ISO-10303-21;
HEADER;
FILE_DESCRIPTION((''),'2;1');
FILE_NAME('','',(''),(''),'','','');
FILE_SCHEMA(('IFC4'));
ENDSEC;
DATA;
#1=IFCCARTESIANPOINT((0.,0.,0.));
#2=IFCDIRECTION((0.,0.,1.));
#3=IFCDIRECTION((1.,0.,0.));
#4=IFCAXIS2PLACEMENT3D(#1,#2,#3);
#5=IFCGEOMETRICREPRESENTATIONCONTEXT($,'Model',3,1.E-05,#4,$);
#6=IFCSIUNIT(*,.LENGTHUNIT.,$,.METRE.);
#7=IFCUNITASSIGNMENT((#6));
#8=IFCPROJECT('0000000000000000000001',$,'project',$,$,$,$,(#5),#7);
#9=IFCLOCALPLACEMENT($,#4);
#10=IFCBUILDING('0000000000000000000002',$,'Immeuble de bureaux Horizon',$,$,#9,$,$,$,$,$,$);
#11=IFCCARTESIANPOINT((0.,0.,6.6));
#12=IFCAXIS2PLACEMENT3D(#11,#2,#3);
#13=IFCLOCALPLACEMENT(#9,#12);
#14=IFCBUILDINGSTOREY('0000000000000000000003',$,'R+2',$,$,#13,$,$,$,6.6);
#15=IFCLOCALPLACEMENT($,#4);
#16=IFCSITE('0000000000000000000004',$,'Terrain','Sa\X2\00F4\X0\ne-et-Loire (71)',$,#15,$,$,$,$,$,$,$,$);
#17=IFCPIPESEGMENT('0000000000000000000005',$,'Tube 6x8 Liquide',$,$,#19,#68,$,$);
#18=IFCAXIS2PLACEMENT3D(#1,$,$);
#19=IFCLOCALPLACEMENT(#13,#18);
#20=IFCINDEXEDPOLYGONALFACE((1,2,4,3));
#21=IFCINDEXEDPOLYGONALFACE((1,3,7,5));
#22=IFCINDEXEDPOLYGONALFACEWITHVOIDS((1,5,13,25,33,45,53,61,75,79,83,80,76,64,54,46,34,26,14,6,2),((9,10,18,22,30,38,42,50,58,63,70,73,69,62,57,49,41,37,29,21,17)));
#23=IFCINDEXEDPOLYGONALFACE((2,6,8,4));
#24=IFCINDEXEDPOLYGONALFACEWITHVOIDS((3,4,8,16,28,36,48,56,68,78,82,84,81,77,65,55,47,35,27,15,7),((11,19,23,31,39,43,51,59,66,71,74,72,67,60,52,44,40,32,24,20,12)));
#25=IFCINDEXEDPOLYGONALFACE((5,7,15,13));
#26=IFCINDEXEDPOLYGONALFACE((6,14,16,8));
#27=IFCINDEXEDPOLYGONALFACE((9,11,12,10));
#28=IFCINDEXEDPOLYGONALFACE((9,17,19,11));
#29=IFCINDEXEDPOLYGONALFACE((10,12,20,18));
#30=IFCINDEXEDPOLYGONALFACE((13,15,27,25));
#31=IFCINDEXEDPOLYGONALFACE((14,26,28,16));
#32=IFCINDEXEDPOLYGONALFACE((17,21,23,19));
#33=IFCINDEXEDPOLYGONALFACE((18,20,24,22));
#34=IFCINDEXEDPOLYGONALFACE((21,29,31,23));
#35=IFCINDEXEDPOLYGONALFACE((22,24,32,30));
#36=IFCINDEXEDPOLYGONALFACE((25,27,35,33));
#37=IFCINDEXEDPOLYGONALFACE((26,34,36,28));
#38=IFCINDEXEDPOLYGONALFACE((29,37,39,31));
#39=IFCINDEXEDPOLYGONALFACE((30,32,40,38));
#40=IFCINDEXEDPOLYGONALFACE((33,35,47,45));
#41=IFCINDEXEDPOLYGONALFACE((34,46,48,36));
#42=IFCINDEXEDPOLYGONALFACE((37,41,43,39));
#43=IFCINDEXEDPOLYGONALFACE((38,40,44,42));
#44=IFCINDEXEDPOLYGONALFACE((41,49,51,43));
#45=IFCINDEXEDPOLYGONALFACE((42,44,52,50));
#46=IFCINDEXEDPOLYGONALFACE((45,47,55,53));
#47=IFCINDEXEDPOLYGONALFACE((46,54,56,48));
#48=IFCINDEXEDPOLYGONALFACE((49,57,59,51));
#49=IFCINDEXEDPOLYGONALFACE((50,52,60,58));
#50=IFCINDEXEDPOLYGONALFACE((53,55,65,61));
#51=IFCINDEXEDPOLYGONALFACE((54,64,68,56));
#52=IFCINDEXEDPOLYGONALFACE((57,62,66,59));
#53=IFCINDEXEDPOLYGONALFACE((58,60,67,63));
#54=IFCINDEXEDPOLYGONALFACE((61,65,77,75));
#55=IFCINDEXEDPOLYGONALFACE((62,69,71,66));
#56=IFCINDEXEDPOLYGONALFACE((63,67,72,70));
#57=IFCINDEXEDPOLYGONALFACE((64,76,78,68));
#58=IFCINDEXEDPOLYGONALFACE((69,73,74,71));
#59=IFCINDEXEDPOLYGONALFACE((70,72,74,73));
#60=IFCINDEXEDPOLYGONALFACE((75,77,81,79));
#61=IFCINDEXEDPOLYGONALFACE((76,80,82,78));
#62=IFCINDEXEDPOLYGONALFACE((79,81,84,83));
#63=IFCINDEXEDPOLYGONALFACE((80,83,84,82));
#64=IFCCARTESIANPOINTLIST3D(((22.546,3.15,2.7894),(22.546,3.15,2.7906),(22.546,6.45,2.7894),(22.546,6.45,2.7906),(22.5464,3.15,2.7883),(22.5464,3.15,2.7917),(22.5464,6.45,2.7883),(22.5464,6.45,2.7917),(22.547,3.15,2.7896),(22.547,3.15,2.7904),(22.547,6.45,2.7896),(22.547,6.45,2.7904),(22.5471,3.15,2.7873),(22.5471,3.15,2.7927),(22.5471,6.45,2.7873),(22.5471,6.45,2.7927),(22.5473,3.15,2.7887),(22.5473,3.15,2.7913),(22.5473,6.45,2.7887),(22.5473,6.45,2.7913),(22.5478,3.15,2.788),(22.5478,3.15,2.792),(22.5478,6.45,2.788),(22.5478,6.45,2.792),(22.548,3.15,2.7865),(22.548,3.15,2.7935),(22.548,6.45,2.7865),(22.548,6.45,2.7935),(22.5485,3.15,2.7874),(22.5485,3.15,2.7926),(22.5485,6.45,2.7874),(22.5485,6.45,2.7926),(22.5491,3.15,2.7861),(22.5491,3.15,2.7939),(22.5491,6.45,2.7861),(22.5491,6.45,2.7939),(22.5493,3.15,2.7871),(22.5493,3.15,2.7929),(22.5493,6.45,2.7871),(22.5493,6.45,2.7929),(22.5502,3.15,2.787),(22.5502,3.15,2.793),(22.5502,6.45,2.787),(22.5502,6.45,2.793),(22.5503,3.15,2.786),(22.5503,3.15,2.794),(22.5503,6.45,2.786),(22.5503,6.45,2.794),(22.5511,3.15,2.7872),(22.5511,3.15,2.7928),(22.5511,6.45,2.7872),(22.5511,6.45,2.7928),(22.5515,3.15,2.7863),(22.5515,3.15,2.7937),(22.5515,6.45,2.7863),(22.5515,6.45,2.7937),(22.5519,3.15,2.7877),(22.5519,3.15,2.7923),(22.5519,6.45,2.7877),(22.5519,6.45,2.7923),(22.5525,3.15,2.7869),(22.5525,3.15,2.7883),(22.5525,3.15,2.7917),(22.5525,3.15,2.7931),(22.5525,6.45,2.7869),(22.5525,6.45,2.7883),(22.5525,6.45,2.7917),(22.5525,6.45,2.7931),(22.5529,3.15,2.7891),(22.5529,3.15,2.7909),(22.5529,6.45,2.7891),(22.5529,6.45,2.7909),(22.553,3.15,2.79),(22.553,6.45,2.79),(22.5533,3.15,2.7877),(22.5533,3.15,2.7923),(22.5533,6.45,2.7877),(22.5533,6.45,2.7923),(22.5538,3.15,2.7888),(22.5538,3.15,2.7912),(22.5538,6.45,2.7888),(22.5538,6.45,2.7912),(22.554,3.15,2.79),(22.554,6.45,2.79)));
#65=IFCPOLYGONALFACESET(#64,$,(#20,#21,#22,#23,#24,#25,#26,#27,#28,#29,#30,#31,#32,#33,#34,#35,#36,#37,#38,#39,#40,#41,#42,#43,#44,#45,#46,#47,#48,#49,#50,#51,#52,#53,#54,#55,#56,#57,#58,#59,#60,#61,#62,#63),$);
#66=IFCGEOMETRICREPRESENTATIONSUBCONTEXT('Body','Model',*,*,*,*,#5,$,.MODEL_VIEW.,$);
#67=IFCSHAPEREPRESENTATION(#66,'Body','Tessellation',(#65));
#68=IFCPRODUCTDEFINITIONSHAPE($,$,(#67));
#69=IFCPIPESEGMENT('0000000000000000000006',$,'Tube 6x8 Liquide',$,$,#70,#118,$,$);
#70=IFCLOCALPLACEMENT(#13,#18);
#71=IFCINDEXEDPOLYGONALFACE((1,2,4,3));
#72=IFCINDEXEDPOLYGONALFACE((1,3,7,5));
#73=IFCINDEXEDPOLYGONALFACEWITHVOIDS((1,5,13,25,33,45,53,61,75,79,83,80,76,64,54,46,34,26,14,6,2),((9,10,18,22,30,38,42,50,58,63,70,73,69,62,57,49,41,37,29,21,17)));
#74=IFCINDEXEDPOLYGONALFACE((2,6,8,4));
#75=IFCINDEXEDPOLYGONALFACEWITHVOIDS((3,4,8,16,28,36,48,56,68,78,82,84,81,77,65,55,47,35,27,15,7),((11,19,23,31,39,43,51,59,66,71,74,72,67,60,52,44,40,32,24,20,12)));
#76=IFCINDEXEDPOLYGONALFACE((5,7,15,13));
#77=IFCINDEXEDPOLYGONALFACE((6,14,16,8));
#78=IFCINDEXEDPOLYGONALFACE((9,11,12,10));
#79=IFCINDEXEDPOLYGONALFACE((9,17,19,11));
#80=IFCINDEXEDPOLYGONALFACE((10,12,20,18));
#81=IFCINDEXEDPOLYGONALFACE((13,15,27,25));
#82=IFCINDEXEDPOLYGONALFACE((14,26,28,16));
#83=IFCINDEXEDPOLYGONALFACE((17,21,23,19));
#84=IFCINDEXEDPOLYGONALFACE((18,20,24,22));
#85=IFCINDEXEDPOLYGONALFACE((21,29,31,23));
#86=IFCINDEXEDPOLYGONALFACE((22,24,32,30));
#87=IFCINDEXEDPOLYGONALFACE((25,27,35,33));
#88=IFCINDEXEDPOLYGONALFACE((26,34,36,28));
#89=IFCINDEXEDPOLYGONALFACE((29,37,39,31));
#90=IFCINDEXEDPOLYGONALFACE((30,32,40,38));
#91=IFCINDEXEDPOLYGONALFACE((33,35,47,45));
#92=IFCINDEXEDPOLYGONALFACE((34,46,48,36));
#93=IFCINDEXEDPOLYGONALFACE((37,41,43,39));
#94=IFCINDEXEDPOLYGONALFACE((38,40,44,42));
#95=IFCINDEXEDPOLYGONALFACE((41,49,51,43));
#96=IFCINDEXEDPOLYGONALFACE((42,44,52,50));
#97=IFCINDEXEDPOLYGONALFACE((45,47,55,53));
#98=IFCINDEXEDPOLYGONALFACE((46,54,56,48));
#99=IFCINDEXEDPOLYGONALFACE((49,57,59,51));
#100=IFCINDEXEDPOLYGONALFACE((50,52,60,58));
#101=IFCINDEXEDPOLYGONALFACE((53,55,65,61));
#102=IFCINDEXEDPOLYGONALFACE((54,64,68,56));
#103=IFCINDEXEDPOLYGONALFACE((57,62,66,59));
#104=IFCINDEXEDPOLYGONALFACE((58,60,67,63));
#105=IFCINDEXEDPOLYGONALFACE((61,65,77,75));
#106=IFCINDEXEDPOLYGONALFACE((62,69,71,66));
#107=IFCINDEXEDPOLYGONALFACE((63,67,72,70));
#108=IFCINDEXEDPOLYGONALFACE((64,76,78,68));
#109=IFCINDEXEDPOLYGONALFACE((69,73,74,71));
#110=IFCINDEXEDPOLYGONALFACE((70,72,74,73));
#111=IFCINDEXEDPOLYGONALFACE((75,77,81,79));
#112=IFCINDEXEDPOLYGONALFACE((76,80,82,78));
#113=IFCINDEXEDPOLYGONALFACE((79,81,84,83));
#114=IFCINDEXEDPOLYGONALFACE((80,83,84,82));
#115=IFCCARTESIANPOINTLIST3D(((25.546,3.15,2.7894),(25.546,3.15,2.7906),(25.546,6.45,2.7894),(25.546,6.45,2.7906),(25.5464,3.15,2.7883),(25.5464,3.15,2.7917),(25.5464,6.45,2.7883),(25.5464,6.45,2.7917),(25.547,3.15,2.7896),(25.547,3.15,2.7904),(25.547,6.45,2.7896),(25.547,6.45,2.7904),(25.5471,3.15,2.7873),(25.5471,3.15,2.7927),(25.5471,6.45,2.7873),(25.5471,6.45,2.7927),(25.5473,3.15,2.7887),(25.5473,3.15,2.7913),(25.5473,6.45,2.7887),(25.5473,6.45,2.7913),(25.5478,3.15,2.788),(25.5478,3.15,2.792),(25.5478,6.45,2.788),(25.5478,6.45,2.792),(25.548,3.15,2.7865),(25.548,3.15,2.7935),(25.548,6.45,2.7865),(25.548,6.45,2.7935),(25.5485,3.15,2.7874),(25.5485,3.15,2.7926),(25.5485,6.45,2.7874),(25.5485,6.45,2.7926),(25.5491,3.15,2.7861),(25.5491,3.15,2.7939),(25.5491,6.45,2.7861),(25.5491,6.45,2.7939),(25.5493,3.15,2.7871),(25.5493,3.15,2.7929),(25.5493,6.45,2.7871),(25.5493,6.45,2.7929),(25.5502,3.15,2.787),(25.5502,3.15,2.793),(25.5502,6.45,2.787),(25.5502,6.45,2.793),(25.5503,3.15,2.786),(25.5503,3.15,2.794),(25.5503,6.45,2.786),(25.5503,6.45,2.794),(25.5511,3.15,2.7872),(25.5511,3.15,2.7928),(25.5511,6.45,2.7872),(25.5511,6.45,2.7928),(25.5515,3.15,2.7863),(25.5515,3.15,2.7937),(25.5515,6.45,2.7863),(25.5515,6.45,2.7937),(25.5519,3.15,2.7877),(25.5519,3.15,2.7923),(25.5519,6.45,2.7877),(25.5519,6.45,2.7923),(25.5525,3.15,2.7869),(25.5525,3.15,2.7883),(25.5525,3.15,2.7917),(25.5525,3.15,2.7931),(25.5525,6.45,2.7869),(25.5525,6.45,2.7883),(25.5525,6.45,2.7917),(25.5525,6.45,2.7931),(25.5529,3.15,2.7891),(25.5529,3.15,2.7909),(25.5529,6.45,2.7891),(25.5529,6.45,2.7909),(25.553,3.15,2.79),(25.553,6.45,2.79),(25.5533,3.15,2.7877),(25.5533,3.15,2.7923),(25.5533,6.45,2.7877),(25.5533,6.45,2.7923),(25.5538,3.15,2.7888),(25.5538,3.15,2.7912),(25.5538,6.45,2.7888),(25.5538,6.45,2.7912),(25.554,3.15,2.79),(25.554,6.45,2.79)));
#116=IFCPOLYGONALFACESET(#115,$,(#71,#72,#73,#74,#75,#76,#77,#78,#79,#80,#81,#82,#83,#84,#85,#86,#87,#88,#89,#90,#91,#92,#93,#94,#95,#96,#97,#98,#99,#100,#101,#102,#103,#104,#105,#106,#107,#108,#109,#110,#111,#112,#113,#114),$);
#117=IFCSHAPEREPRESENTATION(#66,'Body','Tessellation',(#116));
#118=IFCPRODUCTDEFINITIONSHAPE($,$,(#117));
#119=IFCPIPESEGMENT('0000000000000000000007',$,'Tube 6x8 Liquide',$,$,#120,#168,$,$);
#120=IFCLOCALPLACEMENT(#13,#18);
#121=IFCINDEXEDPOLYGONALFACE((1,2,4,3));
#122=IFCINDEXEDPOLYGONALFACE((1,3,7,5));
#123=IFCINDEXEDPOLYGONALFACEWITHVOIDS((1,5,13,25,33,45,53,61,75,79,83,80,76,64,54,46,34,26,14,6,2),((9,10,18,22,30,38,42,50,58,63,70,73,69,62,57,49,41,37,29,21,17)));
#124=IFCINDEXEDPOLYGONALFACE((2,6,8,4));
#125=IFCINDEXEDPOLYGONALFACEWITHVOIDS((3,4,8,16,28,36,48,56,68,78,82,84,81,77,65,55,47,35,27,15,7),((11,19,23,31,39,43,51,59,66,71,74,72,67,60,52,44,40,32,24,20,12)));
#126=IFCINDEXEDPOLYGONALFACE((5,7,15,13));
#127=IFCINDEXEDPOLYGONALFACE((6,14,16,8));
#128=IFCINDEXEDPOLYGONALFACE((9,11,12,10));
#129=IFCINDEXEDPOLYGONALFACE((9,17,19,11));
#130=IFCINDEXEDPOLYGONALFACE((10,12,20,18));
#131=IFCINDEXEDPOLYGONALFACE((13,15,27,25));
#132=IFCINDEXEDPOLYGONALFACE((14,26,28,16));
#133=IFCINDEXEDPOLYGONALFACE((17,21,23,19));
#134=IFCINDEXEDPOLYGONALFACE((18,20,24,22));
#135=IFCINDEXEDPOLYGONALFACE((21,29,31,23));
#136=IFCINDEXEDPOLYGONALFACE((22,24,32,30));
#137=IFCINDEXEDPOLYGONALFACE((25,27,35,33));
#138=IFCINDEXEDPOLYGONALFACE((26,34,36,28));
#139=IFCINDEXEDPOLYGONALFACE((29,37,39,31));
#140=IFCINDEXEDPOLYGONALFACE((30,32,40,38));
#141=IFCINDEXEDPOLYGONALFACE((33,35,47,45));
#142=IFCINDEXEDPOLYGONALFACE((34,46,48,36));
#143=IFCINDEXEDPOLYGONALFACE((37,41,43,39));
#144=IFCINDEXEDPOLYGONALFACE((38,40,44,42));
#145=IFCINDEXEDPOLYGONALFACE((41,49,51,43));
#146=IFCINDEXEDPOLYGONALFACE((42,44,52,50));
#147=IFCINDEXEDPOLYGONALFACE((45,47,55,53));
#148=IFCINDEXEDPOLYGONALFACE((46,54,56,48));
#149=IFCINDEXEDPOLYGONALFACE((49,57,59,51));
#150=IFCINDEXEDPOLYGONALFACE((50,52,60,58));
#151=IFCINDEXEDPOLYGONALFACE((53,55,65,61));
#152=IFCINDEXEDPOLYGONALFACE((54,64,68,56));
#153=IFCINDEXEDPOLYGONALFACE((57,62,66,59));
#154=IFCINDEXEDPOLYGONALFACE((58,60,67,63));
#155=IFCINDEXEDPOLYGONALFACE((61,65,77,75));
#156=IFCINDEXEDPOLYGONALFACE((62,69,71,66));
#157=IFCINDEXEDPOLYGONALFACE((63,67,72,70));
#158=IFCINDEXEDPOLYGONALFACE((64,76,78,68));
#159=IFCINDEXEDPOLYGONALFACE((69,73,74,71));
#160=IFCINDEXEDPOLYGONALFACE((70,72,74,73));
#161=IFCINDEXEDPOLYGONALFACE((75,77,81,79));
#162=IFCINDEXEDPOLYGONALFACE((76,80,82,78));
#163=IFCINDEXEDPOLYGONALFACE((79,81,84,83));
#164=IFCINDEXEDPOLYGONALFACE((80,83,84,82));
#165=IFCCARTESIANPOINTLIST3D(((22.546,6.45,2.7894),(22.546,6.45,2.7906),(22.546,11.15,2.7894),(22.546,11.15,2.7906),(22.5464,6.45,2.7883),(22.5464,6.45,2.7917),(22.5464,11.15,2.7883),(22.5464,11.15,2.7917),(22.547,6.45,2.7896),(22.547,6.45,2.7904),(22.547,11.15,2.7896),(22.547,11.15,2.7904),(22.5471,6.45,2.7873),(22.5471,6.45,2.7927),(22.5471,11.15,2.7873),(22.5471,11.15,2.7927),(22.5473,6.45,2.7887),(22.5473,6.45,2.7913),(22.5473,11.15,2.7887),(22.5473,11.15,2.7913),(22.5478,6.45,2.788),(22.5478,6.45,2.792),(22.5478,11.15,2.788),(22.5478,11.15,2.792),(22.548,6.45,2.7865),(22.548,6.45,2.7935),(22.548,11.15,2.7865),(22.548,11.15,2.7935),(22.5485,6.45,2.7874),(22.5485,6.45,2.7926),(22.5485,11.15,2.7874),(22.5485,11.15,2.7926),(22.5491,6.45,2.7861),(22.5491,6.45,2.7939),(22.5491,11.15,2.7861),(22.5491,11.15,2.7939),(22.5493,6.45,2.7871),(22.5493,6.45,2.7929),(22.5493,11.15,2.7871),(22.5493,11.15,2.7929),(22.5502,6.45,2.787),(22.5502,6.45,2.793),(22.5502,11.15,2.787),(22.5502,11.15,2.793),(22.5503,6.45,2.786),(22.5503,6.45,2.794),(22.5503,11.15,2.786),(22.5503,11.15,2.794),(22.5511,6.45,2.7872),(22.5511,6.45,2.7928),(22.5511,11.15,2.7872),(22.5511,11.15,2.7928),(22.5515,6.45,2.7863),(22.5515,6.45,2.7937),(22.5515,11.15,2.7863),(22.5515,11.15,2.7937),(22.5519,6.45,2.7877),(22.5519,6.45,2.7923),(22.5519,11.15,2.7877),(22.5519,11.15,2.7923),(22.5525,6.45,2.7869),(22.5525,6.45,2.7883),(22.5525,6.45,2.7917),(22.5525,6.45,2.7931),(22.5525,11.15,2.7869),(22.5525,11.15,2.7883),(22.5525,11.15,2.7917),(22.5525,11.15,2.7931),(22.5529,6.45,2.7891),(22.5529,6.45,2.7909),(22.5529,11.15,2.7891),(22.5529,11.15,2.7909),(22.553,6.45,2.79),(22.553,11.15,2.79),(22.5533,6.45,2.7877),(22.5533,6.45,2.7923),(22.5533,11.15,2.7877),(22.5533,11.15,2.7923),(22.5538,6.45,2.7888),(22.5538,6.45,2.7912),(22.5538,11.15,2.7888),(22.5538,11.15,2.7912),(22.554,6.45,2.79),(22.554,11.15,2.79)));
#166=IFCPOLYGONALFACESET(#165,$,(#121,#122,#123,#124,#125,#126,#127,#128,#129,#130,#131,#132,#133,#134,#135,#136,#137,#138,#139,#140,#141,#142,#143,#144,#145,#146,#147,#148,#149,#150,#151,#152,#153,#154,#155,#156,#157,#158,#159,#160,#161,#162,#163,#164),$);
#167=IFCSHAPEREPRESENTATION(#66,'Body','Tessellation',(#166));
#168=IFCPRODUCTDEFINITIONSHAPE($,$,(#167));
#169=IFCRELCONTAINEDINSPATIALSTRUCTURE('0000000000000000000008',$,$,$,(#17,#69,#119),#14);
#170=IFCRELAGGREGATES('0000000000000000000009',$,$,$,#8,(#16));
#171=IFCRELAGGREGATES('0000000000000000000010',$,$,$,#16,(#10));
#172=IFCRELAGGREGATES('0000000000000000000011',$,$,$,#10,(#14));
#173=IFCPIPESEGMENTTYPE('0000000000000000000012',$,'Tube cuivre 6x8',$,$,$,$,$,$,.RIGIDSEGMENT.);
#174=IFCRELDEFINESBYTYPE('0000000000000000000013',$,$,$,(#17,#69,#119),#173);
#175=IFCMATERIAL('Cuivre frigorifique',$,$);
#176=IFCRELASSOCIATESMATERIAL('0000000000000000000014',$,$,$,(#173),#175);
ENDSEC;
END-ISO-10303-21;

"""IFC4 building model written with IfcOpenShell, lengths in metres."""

from ifc_helpers import new_model, si_unit, frame, origin_with_axes, place, context, subcontext, project, spatial, hollow_circle, extrude, material, type_object, element, save


model = new_model("IFC4")

# Units and contexts
model_context = context("Model", 3, precision=1e-05, world=origin_with_axes())
body_context = subcontext(model_context, "Body", "Model", "MODEL_VIEW")
ifc_project = project(units=[si_unit("LENGTHUNIT", "METRE")], contexts=[model_context])

# Site, building, storey
site_placement = place(None, origin_with_axes())
site = spatial("IfcSite", under=ifc_project, at=site_placement, Name="Terrain", Description="Saône-et-Loire (71)")
building_placement = place(None, origin_with_axes())
building = spatial("IfcBuilding", under=site, at=building_placement, Name="Immeuble de bureaux Horizon")
storey_placement = place(building_placement, frame((0.0, 0.0, 6.6), z_axis=(0.0, 0.0, 1.0), x_axis=(1.0, 0.0, 0.0)))
storey = spatial("IfcBuildingStorey", under=building, at=storey_placement, Name="R+2", Elevation=6.6)

# Pipe segments
ifc_material_1 = material(Name="Cuivre frigorifique")
pipe_segment_type_1 = type_object("IfcPipeSegmentType", Name="Tube cuivre 6x8", PredefinedType="RIGIDSEGMENT", material=ifc_material_1)
for number, where, z_axis, x_axis, name in (
    (1, (22.55, 6.45, 2.79), (0.0, -1.0, 0.0), (1.0, 0.0, 0.0), "Tube 6x8 Liquide"),
    (2, (25.55, 6.45, 2.79), (0.0, -1.0, 0.0), (1.0, 0.0, 0.0), "Tube 6x8 Liquide"),
):
    element("IfcPipeSegment", number, at=place(storey_placement, frame(where, z_axis=z_axis, x_axis=x_axis)), inside=storey, type_object=pipe_segment_type_1, Name=name, context=body_context, shape_type="SweptSolid", body=[
        extrude(hollow_circle(Radius=0.004, WallThickness=0.001), origin_with_axes(), (0.0, 0.0, 1.0), 3.3),
    ])
pipe_segment_1_placement = place(storey_placement, frame((22.55, 6.45, 2.79), z_axis=(0.0, 1.0, 0.0), x_axis=(1.0, 0.0, 0.0)))
element("IfcPipeSegment", 3, at=pipe_segment_1_placement, inside=storey, type_object=pipe_segment_type_1, Name="Tube 6x8 Liquide", context=body_context, shape_type="SweptSolid", body=[
    extrude(hollow_circle(Radius=0.004, WallThickness=0.001), origin_with_axes(), (0.0, 0.0, 1.0), 4.7),
])

save(model, "model.ifc")
